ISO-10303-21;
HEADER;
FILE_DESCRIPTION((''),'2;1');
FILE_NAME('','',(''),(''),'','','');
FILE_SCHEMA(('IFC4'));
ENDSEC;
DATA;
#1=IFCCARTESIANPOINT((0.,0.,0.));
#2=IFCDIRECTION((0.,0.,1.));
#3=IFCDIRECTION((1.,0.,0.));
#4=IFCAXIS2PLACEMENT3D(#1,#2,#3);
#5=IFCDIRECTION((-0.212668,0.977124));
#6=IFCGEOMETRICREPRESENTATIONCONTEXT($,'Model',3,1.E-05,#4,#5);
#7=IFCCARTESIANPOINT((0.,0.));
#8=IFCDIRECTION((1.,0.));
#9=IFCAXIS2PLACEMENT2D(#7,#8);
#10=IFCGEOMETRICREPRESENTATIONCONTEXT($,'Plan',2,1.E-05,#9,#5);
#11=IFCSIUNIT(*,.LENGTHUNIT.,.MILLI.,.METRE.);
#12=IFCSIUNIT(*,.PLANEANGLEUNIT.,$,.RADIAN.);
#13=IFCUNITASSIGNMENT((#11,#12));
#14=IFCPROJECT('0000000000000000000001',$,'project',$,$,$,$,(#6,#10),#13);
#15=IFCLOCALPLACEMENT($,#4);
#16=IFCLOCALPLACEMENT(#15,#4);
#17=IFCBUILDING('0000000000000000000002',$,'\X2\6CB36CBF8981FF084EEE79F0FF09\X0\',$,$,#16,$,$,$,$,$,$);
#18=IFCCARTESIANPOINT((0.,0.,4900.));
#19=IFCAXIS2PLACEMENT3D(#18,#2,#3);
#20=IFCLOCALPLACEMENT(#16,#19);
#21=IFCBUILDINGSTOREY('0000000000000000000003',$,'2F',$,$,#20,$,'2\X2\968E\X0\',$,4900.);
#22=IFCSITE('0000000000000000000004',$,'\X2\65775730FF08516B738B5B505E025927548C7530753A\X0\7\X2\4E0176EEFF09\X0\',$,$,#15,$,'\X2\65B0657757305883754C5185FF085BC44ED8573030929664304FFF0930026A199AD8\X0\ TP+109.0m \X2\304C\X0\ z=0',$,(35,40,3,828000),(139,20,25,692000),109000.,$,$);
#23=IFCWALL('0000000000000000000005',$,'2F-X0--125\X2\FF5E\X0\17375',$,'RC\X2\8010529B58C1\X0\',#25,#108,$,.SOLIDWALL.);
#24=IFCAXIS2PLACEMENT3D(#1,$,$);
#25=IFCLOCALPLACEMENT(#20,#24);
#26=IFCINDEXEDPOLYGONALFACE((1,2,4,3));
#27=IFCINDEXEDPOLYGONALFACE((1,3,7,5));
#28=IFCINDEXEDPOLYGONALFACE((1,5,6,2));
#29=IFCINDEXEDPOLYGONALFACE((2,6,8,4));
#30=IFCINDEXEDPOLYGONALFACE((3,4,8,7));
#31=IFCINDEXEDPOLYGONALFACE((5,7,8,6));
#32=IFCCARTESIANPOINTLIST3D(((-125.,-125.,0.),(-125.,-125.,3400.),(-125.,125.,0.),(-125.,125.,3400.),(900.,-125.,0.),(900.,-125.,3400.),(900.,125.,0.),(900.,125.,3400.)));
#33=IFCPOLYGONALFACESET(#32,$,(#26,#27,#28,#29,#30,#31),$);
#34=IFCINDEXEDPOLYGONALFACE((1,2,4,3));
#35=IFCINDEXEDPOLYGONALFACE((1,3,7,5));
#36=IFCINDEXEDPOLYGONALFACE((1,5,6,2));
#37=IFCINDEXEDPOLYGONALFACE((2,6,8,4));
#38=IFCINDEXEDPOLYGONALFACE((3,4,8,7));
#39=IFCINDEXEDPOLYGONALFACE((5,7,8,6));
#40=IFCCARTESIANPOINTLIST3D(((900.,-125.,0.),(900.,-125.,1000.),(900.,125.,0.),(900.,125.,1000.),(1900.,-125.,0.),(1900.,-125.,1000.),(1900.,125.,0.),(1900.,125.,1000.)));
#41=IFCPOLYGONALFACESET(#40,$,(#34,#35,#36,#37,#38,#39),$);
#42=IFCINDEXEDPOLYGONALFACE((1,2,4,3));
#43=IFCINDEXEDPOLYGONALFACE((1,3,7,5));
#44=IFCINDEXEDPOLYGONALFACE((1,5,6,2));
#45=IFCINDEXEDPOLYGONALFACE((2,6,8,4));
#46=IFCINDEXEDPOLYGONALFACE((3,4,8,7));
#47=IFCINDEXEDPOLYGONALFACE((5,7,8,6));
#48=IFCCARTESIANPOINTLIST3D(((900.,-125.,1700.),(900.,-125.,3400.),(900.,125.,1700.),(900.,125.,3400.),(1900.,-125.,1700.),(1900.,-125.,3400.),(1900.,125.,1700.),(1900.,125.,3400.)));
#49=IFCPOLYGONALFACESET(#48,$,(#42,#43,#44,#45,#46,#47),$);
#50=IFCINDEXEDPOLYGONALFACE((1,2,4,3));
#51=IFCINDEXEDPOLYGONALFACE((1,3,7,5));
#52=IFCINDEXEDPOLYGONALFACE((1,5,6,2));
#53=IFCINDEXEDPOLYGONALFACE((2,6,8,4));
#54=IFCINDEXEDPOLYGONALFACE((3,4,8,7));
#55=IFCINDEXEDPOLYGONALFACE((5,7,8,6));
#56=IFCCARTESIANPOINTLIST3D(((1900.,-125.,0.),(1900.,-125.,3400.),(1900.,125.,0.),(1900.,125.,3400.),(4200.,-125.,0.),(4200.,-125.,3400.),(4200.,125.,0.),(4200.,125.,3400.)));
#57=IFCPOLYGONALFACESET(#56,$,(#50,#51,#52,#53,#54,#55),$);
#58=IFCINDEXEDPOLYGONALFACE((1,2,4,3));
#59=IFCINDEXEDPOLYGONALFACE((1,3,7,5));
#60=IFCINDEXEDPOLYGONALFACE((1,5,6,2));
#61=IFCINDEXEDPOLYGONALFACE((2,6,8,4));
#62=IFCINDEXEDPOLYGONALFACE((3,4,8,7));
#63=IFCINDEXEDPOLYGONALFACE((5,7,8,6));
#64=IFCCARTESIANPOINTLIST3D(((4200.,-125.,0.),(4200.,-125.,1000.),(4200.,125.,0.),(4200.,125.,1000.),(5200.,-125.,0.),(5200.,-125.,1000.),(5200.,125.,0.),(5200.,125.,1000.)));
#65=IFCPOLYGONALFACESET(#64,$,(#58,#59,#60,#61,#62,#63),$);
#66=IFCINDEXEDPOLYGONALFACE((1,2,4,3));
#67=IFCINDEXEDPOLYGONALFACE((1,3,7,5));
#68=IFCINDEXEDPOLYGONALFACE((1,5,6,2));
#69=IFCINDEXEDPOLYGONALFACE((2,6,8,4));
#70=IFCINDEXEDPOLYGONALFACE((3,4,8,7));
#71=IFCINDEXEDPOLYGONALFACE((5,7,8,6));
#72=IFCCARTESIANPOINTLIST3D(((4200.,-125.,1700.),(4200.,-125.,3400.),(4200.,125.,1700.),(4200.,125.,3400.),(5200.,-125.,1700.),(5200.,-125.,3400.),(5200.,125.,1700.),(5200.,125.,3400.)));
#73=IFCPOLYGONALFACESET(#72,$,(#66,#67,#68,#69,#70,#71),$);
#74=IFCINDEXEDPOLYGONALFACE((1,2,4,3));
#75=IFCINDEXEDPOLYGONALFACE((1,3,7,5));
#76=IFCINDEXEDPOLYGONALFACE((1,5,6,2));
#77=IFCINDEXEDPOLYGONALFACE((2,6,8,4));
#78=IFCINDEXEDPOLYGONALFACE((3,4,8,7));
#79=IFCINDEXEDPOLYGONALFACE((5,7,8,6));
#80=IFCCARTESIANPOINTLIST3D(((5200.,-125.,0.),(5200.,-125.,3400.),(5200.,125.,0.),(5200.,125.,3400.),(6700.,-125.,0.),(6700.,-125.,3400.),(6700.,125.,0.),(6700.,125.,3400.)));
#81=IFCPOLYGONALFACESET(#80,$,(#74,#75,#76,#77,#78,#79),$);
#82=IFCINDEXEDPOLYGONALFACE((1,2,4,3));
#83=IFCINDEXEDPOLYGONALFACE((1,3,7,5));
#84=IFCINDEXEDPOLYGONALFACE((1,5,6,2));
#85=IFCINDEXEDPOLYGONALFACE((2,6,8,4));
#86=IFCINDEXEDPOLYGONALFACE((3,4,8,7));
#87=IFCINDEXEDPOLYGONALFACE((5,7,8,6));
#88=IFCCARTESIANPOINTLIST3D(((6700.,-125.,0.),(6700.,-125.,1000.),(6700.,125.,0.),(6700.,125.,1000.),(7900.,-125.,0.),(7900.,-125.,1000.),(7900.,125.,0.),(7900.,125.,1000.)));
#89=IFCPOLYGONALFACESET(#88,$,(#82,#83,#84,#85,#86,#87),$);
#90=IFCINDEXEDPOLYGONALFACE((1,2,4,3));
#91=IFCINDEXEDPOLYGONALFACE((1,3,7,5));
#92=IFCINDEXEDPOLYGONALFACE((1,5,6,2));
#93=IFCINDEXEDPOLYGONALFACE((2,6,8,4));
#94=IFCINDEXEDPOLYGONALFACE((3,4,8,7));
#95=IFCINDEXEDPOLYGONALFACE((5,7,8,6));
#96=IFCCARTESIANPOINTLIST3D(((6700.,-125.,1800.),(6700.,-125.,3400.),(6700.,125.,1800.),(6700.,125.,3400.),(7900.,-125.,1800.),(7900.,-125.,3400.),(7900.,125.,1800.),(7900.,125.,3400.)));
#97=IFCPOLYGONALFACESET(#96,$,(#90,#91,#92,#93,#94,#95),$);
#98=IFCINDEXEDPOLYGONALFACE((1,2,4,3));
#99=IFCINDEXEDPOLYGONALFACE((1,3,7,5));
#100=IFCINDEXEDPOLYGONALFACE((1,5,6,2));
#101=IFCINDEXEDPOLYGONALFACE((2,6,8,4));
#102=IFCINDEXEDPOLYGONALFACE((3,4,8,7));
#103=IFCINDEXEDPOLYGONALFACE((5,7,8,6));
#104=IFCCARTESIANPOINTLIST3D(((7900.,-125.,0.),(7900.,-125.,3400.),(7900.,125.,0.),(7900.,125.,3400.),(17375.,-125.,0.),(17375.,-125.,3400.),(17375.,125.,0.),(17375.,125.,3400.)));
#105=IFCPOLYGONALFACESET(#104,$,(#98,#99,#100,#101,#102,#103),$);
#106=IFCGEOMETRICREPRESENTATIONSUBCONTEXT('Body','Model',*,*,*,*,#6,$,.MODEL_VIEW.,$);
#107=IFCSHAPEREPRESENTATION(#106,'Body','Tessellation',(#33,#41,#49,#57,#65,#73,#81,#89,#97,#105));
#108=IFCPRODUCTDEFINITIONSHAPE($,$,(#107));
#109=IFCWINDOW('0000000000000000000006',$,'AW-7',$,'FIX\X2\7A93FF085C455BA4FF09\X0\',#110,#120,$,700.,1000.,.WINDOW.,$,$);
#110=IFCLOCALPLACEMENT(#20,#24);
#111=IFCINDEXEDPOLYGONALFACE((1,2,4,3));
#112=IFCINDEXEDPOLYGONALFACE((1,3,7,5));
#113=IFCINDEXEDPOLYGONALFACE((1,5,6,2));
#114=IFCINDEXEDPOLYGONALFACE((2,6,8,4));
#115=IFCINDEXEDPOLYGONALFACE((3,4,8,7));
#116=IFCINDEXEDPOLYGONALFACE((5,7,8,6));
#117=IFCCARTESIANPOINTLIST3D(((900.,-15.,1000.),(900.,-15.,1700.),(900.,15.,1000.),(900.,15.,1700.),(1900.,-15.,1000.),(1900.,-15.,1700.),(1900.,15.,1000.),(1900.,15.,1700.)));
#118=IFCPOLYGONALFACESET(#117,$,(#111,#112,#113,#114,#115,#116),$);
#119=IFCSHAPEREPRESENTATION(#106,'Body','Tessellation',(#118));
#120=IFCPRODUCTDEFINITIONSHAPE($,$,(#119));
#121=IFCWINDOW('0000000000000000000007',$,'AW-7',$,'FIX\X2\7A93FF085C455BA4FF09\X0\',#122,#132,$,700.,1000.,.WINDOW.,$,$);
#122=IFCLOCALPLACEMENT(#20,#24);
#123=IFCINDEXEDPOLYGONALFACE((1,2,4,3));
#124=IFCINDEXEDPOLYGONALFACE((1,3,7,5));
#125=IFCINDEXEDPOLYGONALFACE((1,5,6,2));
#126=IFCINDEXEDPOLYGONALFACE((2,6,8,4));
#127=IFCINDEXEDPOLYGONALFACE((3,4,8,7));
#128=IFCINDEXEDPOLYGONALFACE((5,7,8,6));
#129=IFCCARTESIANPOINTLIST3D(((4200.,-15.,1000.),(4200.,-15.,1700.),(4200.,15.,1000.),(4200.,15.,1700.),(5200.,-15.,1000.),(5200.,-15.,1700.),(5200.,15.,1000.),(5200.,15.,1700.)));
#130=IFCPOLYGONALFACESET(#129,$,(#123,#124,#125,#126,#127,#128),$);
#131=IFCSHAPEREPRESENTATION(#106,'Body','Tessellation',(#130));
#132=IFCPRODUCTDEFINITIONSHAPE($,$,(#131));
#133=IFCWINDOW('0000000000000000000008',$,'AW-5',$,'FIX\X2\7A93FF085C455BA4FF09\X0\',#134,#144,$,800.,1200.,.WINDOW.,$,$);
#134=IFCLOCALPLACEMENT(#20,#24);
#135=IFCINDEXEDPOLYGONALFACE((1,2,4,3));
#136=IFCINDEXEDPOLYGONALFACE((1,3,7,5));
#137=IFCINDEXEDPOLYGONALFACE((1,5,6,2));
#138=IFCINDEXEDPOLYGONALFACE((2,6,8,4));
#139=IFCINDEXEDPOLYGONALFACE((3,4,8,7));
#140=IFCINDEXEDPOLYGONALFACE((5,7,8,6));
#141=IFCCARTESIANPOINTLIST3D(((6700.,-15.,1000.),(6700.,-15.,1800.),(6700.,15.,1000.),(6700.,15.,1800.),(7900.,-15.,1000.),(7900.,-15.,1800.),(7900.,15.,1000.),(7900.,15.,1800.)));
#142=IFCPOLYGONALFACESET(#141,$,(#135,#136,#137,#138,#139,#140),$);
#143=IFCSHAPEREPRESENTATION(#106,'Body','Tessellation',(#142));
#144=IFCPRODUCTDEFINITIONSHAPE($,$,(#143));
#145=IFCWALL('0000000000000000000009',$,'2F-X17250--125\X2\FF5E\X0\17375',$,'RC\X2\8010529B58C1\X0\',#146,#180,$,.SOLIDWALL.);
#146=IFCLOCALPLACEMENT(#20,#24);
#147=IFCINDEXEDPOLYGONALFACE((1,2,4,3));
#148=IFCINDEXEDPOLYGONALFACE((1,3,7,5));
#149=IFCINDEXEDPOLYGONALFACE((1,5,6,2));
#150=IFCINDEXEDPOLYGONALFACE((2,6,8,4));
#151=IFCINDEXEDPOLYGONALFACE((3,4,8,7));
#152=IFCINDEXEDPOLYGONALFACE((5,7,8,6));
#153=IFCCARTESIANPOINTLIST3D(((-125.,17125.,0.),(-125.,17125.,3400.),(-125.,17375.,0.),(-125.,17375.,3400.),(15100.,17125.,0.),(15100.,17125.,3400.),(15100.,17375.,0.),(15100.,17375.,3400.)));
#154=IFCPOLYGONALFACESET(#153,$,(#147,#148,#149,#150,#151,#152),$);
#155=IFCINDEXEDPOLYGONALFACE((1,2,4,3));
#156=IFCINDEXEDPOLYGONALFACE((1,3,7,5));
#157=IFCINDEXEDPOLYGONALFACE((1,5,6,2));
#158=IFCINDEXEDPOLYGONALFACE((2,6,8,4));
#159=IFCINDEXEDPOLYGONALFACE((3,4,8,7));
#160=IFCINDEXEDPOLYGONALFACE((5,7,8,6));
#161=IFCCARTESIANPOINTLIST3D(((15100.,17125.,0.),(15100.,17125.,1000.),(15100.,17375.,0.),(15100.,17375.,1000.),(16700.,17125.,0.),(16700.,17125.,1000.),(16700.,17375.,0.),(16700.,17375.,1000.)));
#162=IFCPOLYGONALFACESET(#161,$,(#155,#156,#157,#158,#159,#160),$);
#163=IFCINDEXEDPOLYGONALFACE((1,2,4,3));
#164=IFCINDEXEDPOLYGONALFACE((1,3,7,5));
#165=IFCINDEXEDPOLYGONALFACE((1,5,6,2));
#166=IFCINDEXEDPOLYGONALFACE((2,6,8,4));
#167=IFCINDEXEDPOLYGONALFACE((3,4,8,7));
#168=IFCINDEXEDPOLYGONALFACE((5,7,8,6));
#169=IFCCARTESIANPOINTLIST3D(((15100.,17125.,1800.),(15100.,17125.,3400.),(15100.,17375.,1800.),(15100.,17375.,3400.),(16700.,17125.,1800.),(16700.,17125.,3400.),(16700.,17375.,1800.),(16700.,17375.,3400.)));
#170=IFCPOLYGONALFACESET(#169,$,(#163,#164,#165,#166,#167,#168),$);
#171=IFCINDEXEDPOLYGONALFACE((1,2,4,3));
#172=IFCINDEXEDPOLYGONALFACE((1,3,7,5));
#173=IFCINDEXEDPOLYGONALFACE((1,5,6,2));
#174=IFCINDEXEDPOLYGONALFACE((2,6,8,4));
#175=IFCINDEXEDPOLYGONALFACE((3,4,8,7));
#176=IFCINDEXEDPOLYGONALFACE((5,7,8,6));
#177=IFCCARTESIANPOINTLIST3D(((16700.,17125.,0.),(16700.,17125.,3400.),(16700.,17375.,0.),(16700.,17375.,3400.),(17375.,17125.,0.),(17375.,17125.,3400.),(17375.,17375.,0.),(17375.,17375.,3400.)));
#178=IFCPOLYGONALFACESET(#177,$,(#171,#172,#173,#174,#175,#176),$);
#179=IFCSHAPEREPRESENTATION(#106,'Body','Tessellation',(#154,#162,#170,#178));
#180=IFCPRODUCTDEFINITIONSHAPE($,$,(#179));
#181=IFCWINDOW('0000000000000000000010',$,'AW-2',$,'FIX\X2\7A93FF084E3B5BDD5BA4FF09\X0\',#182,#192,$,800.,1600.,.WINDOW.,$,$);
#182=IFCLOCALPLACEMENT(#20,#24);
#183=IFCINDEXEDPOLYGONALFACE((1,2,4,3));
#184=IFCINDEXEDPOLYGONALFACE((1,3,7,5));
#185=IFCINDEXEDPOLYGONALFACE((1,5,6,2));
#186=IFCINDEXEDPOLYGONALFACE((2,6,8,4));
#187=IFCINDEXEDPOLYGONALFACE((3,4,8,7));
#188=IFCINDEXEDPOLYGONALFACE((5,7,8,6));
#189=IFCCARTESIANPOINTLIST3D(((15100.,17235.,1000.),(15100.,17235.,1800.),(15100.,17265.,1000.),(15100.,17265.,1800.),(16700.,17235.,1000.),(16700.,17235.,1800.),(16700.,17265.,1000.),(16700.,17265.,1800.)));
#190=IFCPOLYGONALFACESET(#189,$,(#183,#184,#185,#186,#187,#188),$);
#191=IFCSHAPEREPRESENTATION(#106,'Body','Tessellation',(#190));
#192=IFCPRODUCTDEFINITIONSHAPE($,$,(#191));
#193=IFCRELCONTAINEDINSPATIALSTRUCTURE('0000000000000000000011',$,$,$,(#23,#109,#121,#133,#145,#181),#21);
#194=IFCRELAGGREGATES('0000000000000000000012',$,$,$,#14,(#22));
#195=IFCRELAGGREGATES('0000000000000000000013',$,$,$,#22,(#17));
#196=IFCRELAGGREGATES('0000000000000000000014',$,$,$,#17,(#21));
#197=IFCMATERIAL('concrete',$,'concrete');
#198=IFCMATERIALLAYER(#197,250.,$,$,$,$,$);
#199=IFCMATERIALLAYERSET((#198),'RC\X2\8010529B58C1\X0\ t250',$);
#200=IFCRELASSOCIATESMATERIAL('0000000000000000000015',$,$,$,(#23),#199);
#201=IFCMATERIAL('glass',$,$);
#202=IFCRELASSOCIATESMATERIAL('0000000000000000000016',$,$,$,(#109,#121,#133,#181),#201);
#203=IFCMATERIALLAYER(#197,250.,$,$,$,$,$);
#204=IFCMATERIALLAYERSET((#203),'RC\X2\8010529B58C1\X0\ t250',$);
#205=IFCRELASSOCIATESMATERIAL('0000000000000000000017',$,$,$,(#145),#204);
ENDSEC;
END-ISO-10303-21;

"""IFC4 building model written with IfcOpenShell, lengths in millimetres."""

from ifc_helpers import new_model, si_unit, direction, frame, frame_2d, origin, origin_with_axes, origin_2d_with_axis, place, context, subcontext, project, spatial, rectangle, extrude, material, layer, layer_set, layer_usage, element, fill, save


model = new_model("IFC4")

# Units and contexts
model_context = context("Model", 3, precision=1e-05, world=origin_with_axes(), true_north=direction((-0.212668, 0.977124)))
plan_context = context("Plan", 2, precision=1e-05, world=origin_2d_with_axis(), true_north=direction((-0.212668, 0.977124)))
body_context = subcontext(model_context, "Body", "Model", "MODEL_VIEW")
ifc_project = project(units=[si_unit("LENGTHUNIT", "METRE", prefix="MILLI"), si_unit("PLANEANGLEUNIT", "RADIAN")], contexts=[model_context, plan_context])

# Site, building, storey
site_placement = place(None, origin_with_axes())
site = spatial("IfcSite", under=ifc_project, at=site_placement, Name="敷地（八王子市大和田町7丁目）", LongName="新敷地境界内（寄付地を除く）。標高 TP+109.0m が z=0", RefLatitude=(35, 40, 3, 828000), RefLongitude=(139, 20, 25, 692000), RefElevation=109000.0)
building_placement = place(site_placement, origin_with_axes())
building = spatial("IfcBuilding", under=site, at=building_placement, Name="河沿要（仮称）")
storey_placement = place(building_placement, frame((0.0, 0.0, 4900.0), z_axis=(0.0, 0.0, 1.0), x_axis=(1.0, 0.0, 0.0)))
storey = spatial("IfcBuildingStorey", under=building, at=storey_placement, Name="2F", LongName="2階", Elevation=4900.0)

# Wall, openings, windows
ifc_material_1 = material(Name="concrete", Category="concrete")
ifc_layer_1 = layer(ifc_material_1, 250.0)
ifc_layer_set_1 = layer_set([ifc_layer_1], Name="RC耐力壁 t250")
ifc_layer_usage_1 = layer_usage(ifc_layer_set_1, "AXIS2", "POSITIVE", 0.0)
wall_1_placement = place(storey_placement, origin_with_axes())
wall_1 = element("IfcWall", 1, at=wall_1_placement, inside=storey, material=ifc_layer_usage_1, Name="2F-X0--125～17375", ObjectType="RC耐力壁", PredefinedType="SOLIDWALL", context=body_context, shape_type="SweptSolid", body=[
    extrude(rectangle(XDim=1025.0, YDim=250.0, at=frame_2d((387.5, 0.0))), origin(), (0.0, 0.0, 1.0), 3400.0),
    extrude(rectangle(XDim=1000.0, YDim=250.0, at=frame_2d((1400.0, 0.0))), origin(), (0.0, 0.0, 1.0), 1000.0),
    extrude(rectangle(XDim=1000.0, YDim=250.0, at=frame_2d((1400.0, 0.0))), frame((0.0, 0.0, 1700.0)), (0.0, 0.0, 1.0), 1700.0),
    extrude(rectangle(XDim=2300.0, YDim=250.0, at=frame_2d((3050.0, 0.0))), origin(), (0.0, 0.0, 1.0), 3400.0),
    extrude(rectangle(XDim=1000.0, YDim=250.0, at=frame_2d((4700.0, 0.0))), origin(), (0.0, 0.0, 1.0), 1000.0),
    extrude(rectangle(XDim=1000.0, YDim=250.0, at=frame_2d((4700.0, 0.0))), frame((0.0, 0.0, 1700.0)), (0.0, 0.0, 1.0), 1700.0),
    extrude(rectangle(XDim=1500.0, YDim=250.0, at=frame_2d((5950.0, 0.0))), origin(), (0.0, 0.0, 1.0), 3400.0),
    extrude(rectangle(XDim=1200.0, YDim=250.0, at=frame_2d((7300.0, 0.0))), origin(), (0.0, 0.0, 1.0), 1000.0),
    extrude(rectangle(XDim=1200.0, YDim=250.0, at=frame_2d((7300.0, 0.0))), frame((0.0, 0.0, 1800.0)), (0.0, 0.0, 1.0), 1600.0),
    extrude(rectangle(XDim=9475.0, YDim=250.0, at=frame_2d((12637.5, 0.0))), origin(), (0.0, 0.0, 1.0), 3400.0),
])
opening_1_placement = place(storey_placement, origin_with_axes())
opening_1 = element("IfcOpeningElement", 2, at=opening_1_placement, inside=storey, cuts=wall_1, PredefinedType="OPENING", context=body_context, shape_type="SweptSolid", body=[
    extrude(rectangle(XDim=1000.0, YDim=300.0, at=frame_2d((1400.0, 0.0))), frame((0.0, 0.0, 1000.0)), (0.0, 0.0, 1.0), 700.0),
])
opening_2_placement = place(storey_placement, origin_with_axes())
opening_2 = element("IfcOpeningElement", 3, at=opening_2_placement, inside=storey, cuts=wall_1, PredefinedType="OPENING", context=body_context, shape_type="SweptSolid", body=[
    extrude(rectangle(XDim=1000.0, YDim=300.0, at=frame_2d((4700.0, 0.0))), frame((0.0, 0.0, 1000.0)), (0.0, 0.0, 1.0), 700.0),
])
opening_3_placement = place(storey_placement, origin_with_axes())
opening_3 = element("IfcOpeningElement", 4, at=opening_3_placement, inside=storey, cuts=wall_1, PredefinedType="OPENING", context=body_context, shape_type="SweptSolid", body=[
    extrude(rectangle(XDim=1200.0, YDim=300.0, at=frame_2d((7300.0, 0.0))), frame((0.0, 0.0, 1000.0)), (0.0, 0.0, 1.0), 800.0),
])
ifc_material_2 = material(Name="glass")
window_1_placement = place(storey_placement, origin_with_axes())
window_1 = element("IfcWindow", 5, at=window_1_placement, inside=storey, material=ifc_material_2, Name="AW-7", ObjectType="FIX窓（居室）", OverallHeight=700.0, OverallWidth=1000.0, PredefinedType="WINDOW", context=body_context, shape_type="SweptSolid", body=[
    extrude(rectangle(XDim=1000.0, YDim=30.0, at=frame_2d((1400.0, 0.0))), frame((0.0, 0.0, 1000.0)), (0.0, 0.0, 1.0), 700.0),
])
fill(opening_1, window_1)
window_2_placement = place(storey_placement, origin_with_axes())
window_2 = element("IfcWindow", 6, at=window_2_placement, inside=storey, material=ifc_material_2, Name="AW-7", ObjectType="FIX窓（居室）", OverallHeight=700.0, OverallWidth=1000.0, PredefinedType="WINDOW", context=body_context, shape_type="SweptSolid", body=[
    extrude(rectangle(XDim=1000.0, YDim=30.0, at=frame_2d((4700.0, 0.0))), frame((0.0, 0.0, 1000.0)), (0.0, 0.0, 1.0), 700.0),
])
fill(opening_2, window_2)
window_3_placement = place(storey_placement, origin_with_axes())
window_3 = element("IfcWindow", 7, at=window_3_placement, inside=storey, material=ifc_material_2, Name="AW-5", ObjectType="FIX窓（居室）", OverallHeight=800.0, OverallWidth=1200.0, PredefinedType="WINDOW", context=body_context, shape_type="SweptSolid", body=[
    extrude(rectangle(XDim=1200.0, YDim=30.0, at=frame_2d((7300.0, 0.0))), frame((0.0, 0.0, 1000.0)), (0.0, 0.0, 1.0), 800.0),
])
fill(opening_3, window_3)

# Wall, opening, window
ifc_layer_2 = layer(ifc_material_1, 250.0)
ifc_layer_set_2 = layer_set([ifc_layer_2], Name="RC耐力壁 t250")
ifc_layer_usage_2 = layer_usage(ifc_layer_set_2, "AXIS2", "POSITIVE", 0.0)
wall_2_placement = place(storey_placement, origin_with_axes())
wall_2 = element("IfcWall", 8, at=wall_2_placement, inside=storey, material=ifc_layer_usage_2, Name="2F-X17250--125～17375", ObjectType="RC耐力壁", PredefinedType="SOLIDWALL", context=body_context, shape_type="SweptSolid", body=[
    extrude(rectangle(XDim=15225.0, YDim=250.0, at=frame_2d((7487.5, 17250.0))), origin(), (0.0, 0.0, 1.0), 3400.0),
    extrude(rectangle(XDim=1600.0, YDim=250.0, at=frame_2d((15900.0, 17250.0))), origin(), (0.0, 0.0, 1.0), 1000.0),
    extrude(rectangle(XDim=1600.0, YDim=250.0, at=frame_2d((15900.0, 17250.0))), frame((0.0, 0.0, 1800.0)), (0.0, 0.0, 1.0), 1600.0),
    extrude(rectangle(XDim=675.0, YDim=250.0, at=frame_2d((17037.5, 17250.0))), origin(), (0.0, 0.0, 1.0), 3400.0),
])
opening_4_placement = place(storey_placement, origin_with_axes())
opening_4 = element("IfcOpeningElement", 9, at=opening_4_placement, inside=storey, cuts=wall_2, PredefinedType="OPENING", context=body_context, shape_type="SweptSolid", body=[
    extrude(rectangle(XDim=1600.0, YDim=300.0, at=frame_2d((15900.0, 17250.0))), frame((0.0, 0.0, 1000.0)), (0.0, 0.0, 1.0), 800.0),
])
window_4_placement = place(storey_placement, origin_with_axes())
window_4 = element("IfcWindow", 10, at=window_4_placement, inside=storey, material=ifc_material_2, Name="AW-2", ObjectType="FIX窓（主寝室）", OverallHeight=800.0, OverallWidth=1600.0, PredefinedType="WINDOW", context=body_context, shape_type="SweptSolid", body=[
    extrude(rectangle(XDim=1600.0, YDim=30.0, at=frame_2d((15900.0, 17250.0))), frame((0.0, 0.0, 1000.0)), (0.0, 0.0, 1.0), 800.0),
])
fill(opening_4, window_4)

save(model, "model.ifc")
